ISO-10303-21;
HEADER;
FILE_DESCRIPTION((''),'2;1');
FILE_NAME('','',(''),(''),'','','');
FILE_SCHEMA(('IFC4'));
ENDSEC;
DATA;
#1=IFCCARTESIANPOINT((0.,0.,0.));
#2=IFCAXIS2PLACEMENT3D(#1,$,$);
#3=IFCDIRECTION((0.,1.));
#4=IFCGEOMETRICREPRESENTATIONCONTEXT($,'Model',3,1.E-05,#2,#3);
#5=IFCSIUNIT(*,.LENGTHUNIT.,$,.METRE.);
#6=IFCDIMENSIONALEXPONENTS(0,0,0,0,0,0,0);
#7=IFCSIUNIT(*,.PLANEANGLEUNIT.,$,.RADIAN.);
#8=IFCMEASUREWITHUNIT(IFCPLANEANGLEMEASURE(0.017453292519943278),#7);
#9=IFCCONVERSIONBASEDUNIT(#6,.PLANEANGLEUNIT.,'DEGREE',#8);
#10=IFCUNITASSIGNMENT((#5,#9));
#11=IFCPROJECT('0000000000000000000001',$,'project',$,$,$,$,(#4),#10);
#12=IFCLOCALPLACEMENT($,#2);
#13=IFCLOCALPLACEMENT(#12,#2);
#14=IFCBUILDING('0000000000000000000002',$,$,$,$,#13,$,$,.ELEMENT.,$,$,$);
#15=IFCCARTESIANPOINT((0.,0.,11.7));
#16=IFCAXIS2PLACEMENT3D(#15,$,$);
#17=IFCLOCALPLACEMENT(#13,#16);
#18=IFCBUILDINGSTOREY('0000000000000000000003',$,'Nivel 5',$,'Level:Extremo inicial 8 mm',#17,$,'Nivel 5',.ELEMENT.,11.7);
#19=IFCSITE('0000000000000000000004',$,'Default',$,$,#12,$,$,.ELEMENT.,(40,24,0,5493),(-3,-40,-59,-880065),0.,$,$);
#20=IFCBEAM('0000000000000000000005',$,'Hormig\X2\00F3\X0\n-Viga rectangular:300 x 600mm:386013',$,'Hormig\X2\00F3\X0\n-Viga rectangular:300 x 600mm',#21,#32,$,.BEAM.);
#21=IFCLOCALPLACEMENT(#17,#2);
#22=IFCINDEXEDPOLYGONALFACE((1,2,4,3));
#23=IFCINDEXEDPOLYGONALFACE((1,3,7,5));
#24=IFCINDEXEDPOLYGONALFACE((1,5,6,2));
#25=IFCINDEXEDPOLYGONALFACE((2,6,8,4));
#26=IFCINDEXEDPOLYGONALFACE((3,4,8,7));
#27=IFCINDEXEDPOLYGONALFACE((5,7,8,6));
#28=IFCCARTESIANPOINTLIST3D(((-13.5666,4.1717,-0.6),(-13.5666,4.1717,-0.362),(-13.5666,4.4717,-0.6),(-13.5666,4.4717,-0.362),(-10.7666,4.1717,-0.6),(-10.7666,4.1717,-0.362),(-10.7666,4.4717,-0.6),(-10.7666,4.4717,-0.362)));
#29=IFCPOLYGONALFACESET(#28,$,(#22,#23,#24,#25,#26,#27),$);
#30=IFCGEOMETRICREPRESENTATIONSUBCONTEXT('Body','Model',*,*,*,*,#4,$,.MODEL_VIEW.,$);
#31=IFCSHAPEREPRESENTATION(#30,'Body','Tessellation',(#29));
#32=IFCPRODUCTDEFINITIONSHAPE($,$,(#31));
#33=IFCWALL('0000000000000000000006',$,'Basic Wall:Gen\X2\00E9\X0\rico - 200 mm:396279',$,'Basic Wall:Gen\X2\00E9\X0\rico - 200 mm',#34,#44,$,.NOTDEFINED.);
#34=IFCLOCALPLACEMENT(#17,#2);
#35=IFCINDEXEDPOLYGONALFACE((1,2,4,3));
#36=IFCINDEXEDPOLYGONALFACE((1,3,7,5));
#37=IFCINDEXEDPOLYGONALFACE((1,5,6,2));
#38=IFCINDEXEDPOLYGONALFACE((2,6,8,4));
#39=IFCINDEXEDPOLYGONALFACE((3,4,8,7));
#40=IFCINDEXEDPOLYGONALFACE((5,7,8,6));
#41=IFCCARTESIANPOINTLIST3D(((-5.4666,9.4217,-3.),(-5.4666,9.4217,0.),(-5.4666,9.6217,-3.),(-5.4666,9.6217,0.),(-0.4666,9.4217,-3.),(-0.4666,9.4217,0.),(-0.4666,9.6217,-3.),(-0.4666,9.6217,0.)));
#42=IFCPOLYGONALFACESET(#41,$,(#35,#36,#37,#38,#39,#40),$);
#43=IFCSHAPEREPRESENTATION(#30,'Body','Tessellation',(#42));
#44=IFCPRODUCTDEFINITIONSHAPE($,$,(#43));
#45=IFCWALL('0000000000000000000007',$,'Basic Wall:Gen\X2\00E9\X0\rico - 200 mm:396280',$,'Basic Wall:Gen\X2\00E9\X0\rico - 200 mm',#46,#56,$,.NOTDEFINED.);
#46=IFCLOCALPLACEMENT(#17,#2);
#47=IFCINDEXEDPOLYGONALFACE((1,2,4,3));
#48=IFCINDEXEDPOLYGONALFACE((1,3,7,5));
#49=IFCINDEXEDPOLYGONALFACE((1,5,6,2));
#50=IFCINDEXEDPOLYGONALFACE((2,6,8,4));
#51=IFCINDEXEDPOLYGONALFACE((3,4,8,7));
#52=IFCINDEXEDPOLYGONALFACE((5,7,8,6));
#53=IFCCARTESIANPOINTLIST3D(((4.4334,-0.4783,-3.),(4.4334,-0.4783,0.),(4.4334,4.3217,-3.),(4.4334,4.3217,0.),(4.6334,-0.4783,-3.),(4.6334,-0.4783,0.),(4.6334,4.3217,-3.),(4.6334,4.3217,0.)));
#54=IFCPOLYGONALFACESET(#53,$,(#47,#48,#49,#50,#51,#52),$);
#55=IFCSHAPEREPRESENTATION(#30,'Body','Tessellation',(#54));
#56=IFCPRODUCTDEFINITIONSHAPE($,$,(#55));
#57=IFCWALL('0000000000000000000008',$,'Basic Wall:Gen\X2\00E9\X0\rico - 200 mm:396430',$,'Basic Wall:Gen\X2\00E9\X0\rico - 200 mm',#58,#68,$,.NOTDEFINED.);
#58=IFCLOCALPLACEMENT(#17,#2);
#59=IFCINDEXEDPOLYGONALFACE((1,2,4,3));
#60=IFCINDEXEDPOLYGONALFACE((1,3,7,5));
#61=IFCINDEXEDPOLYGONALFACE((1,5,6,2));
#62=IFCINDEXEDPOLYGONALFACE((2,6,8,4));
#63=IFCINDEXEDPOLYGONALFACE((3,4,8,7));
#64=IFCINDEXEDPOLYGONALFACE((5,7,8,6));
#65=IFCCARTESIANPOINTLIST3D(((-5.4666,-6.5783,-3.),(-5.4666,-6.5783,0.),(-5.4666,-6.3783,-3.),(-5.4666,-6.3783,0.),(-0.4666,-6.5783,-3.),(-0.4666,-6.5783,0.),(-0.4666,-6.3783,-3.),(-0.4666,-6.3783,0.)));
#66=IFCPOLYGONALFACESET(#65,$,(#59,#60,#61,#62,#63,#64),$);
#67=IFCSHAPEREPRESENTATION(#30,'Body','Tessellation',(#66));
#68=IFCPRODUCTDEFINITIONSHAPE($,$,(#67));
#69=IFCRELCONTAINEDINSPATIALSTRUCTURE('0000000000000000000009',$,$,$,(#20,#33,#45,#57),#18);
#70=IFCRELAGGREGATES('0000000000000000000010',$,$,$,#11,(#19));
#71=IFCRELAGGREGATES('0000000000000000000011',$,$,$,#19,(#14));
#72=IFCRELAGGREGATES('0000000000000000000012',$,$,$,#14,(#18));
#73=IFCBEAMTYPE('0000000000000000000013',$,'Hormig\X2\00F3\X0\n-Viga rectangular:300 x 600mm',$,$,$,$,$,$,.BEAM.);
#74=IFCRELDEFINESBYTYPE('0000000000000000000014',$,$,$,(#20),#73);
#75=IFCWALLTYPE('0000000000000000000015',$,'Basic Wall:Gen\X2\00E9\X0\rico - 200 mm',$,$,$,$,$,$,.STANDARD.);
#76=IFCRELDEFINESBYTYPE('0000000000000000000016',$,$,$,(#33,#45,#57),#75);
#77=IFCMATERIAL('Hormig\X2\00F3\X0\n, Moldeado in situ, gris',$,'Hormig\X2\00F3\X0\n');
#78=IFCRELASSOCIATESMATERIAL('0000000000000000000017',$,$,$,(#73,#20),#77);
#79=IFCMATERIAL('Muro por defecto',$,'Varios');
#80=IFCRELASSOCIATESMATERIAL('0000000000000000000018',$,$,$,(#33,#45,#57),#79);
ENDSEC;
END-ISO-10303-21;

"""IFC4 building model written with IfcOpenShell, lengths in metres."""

from ifc_helpers import new_model, entity, si_unit, converted_unit, direction, frame, origin, place, context, subcontext, project, spatial, indexed_curve, outline, extrude, source, transform, mapped, material, type_object, type_shapes, element, save


model = new_model("IFC4")

# Units and contexts
model_context = context("Model", 3, precision=1e-05, world=origin(), true_north=direction((0.0, 1.0)))
body_context = subcontext(model_context, "Body", "Model", "MODEL_VIEW")
ifc_project = project(units=[si_unit("LENGTHUNIT", "METRE"), converted_unit("PLANEANGLEUNIT", "DEGREE", entity("IfcPlaneAngleMeasure", 0.017453292519943278), si_unit("PLANEANGLEUNIT", "RADIAN"), dimensions=[0, 0, 0, 0, 0, 0, 0])], contexts=[model_context])

# Site, building, storey
site_placement = place(None, origin())
site = spatial("IfcSite", under=ifc_project, at=site_placement, Name="Default", CompositionType="ELEMENT", RefLatitude=(40, 24, 0, 5493), RefLongitude=(-3, -40, -59, -880065), RefElevation=0.0)
building_placement = place(site_placement, origin())
building = spatial("IfcBuilding", under=site, at=building_placement, CompositionType="ELEMENT")
storey_placement = place(building_placement, frame((0.0, 0.0, 11.7)))
storey = spatial("IfcBuildingStorey", under=building, at=storey_placement, Name="Nivel 5", ObjectType="Level:Extremo inicial 8 mm", LongName="Nivel 5", CompositionType="ELEMENT", Elevation=11.7)

# Shared definitions
ifc_material_1 = material(Name="Hormigón, Moldeado in situ, gris", Category="Hormigón")

# Beam
beam_type_1 = type_object("IfcBeamType", Name="Hormigón-Viga rectangular:300 x 600mm", PredefinedType="BEAM", material=ifc_material_1)
shared_shape_1 = source(origin(), body_context, "Body", "SweptSolid", [
    extrude(outline(indexed_curve([(-0.119, -0.15), (0.119, -0.15), (0.119, 0.15), (-0.119, 0.15), (-0.119, -0.15)], self_intersect=False)), frame((-10.7666, 4.3217, 11.219), z_axis=(-1.0, 0.0, 0.0), x_axis=(0.0, 0.0, -1.0)), (0.0, 0.0, 1.0), 2.8),
])
type_shapes(beam_type_1, [shared_shape_1])
beam_1_placement = place(storey_placement, frame((0.0, 0.0, -11.7)))
element("IfcBeam", 1, at=beam_1_placement, inside=storey, type_object=beam_type_1, material=ifc_material_1, Name="Hormigón-Viga rectangular:300 x 600mm:386013", ObjectType="Hormigón-Viga rectangular:300 x 600mm", PredefinedType="BEAM", context=body_context, shape_type="MappedRepresentation", body=[
    mapped(shared_shape_1, transform((0.0, 0.0, 0.0), scale=1.0)),
])

# Walls
ifc_material_2 = material(Name="Muro por defecto", Category="Varios")
wall_type = type_object("IfcWallType", Name="Basic Wall:Genérico - 200 mm", PredefinedType="STANDARD")
wall_1_placement = place(storey_placement, frame((-5.4666, 9.5217, -3.0)))
element("IfcWall", 2, at=wall_1_placement, inside=storey, type_object=wall_type, material=ifc_material_2, Name="Basic Wall:Genérico - 200 mm:396279", ObjectType="Basic Wall:Genérico - 200 mm", PredefinedType="NOTDEFINED", context=body_context, shape_type="SweptSolid", body=[
    extrude(outline(indexed_curve([(5.0, 0.1), (0.0, 0.1), (0.0, -0.1), (5.0, -0.1), (5.0, 0.1)], self_intersect=False)), origin(), (0.0, 0.0, 1.0), 3.0),
])
wall_2_placement = place(storey_placement, frame((4.5334, 4.3217, -3.0), z_axis=(0.0, 0.0, 1.0), x_axis=(0.0, -1.0, 0.0)))
element("IfcWall", 3, at=wall_2_placement, inside=storey, type_object=wall_type, material=ifc_material_2, Name="Basic Wall:Genérico - 200 mm:396280", ObjectType="Basic Wall:Genérico - 200 mm", PredefinedType="NOTDEFINED", context=body_context, shape_type="SweptSolid", body=[
    extrude(outline(indexed_curve([(4.8, 0.1), (0.0, 0.1), (0.0, -0.1), (4.8, -0.1), (4.8, 0.1)], self_intersect=False)), origin(), (0.0, 0.0, 1.0), 3.0),
])
wall_3_placement = place(storey_placement, frame((-5.4666, -6.4783, -3.0)))
element("IfcWall", 4, at=wall_3_placement, inside=storey, type_object=wall_type, material=ifc_material_2, Name="Basic Wall:Genérico - 200 mm:396430", ObjectType="Basic Wall:Genérico - 200 mm", PredefinedType="NOTDEFINED", context=body_context, shape_type="SweptSolid", body=[
    extrude(outline(indexed_curve([(5.0, 0.1), (0.0, 0.1), (0.0, -0.1), (5.0, -0.1), (5.0, 0.1)], self_intersect=False)), origin(), (0.0, 0.0, 1.0), 3.0),
])

save(model, "model.ifc")
